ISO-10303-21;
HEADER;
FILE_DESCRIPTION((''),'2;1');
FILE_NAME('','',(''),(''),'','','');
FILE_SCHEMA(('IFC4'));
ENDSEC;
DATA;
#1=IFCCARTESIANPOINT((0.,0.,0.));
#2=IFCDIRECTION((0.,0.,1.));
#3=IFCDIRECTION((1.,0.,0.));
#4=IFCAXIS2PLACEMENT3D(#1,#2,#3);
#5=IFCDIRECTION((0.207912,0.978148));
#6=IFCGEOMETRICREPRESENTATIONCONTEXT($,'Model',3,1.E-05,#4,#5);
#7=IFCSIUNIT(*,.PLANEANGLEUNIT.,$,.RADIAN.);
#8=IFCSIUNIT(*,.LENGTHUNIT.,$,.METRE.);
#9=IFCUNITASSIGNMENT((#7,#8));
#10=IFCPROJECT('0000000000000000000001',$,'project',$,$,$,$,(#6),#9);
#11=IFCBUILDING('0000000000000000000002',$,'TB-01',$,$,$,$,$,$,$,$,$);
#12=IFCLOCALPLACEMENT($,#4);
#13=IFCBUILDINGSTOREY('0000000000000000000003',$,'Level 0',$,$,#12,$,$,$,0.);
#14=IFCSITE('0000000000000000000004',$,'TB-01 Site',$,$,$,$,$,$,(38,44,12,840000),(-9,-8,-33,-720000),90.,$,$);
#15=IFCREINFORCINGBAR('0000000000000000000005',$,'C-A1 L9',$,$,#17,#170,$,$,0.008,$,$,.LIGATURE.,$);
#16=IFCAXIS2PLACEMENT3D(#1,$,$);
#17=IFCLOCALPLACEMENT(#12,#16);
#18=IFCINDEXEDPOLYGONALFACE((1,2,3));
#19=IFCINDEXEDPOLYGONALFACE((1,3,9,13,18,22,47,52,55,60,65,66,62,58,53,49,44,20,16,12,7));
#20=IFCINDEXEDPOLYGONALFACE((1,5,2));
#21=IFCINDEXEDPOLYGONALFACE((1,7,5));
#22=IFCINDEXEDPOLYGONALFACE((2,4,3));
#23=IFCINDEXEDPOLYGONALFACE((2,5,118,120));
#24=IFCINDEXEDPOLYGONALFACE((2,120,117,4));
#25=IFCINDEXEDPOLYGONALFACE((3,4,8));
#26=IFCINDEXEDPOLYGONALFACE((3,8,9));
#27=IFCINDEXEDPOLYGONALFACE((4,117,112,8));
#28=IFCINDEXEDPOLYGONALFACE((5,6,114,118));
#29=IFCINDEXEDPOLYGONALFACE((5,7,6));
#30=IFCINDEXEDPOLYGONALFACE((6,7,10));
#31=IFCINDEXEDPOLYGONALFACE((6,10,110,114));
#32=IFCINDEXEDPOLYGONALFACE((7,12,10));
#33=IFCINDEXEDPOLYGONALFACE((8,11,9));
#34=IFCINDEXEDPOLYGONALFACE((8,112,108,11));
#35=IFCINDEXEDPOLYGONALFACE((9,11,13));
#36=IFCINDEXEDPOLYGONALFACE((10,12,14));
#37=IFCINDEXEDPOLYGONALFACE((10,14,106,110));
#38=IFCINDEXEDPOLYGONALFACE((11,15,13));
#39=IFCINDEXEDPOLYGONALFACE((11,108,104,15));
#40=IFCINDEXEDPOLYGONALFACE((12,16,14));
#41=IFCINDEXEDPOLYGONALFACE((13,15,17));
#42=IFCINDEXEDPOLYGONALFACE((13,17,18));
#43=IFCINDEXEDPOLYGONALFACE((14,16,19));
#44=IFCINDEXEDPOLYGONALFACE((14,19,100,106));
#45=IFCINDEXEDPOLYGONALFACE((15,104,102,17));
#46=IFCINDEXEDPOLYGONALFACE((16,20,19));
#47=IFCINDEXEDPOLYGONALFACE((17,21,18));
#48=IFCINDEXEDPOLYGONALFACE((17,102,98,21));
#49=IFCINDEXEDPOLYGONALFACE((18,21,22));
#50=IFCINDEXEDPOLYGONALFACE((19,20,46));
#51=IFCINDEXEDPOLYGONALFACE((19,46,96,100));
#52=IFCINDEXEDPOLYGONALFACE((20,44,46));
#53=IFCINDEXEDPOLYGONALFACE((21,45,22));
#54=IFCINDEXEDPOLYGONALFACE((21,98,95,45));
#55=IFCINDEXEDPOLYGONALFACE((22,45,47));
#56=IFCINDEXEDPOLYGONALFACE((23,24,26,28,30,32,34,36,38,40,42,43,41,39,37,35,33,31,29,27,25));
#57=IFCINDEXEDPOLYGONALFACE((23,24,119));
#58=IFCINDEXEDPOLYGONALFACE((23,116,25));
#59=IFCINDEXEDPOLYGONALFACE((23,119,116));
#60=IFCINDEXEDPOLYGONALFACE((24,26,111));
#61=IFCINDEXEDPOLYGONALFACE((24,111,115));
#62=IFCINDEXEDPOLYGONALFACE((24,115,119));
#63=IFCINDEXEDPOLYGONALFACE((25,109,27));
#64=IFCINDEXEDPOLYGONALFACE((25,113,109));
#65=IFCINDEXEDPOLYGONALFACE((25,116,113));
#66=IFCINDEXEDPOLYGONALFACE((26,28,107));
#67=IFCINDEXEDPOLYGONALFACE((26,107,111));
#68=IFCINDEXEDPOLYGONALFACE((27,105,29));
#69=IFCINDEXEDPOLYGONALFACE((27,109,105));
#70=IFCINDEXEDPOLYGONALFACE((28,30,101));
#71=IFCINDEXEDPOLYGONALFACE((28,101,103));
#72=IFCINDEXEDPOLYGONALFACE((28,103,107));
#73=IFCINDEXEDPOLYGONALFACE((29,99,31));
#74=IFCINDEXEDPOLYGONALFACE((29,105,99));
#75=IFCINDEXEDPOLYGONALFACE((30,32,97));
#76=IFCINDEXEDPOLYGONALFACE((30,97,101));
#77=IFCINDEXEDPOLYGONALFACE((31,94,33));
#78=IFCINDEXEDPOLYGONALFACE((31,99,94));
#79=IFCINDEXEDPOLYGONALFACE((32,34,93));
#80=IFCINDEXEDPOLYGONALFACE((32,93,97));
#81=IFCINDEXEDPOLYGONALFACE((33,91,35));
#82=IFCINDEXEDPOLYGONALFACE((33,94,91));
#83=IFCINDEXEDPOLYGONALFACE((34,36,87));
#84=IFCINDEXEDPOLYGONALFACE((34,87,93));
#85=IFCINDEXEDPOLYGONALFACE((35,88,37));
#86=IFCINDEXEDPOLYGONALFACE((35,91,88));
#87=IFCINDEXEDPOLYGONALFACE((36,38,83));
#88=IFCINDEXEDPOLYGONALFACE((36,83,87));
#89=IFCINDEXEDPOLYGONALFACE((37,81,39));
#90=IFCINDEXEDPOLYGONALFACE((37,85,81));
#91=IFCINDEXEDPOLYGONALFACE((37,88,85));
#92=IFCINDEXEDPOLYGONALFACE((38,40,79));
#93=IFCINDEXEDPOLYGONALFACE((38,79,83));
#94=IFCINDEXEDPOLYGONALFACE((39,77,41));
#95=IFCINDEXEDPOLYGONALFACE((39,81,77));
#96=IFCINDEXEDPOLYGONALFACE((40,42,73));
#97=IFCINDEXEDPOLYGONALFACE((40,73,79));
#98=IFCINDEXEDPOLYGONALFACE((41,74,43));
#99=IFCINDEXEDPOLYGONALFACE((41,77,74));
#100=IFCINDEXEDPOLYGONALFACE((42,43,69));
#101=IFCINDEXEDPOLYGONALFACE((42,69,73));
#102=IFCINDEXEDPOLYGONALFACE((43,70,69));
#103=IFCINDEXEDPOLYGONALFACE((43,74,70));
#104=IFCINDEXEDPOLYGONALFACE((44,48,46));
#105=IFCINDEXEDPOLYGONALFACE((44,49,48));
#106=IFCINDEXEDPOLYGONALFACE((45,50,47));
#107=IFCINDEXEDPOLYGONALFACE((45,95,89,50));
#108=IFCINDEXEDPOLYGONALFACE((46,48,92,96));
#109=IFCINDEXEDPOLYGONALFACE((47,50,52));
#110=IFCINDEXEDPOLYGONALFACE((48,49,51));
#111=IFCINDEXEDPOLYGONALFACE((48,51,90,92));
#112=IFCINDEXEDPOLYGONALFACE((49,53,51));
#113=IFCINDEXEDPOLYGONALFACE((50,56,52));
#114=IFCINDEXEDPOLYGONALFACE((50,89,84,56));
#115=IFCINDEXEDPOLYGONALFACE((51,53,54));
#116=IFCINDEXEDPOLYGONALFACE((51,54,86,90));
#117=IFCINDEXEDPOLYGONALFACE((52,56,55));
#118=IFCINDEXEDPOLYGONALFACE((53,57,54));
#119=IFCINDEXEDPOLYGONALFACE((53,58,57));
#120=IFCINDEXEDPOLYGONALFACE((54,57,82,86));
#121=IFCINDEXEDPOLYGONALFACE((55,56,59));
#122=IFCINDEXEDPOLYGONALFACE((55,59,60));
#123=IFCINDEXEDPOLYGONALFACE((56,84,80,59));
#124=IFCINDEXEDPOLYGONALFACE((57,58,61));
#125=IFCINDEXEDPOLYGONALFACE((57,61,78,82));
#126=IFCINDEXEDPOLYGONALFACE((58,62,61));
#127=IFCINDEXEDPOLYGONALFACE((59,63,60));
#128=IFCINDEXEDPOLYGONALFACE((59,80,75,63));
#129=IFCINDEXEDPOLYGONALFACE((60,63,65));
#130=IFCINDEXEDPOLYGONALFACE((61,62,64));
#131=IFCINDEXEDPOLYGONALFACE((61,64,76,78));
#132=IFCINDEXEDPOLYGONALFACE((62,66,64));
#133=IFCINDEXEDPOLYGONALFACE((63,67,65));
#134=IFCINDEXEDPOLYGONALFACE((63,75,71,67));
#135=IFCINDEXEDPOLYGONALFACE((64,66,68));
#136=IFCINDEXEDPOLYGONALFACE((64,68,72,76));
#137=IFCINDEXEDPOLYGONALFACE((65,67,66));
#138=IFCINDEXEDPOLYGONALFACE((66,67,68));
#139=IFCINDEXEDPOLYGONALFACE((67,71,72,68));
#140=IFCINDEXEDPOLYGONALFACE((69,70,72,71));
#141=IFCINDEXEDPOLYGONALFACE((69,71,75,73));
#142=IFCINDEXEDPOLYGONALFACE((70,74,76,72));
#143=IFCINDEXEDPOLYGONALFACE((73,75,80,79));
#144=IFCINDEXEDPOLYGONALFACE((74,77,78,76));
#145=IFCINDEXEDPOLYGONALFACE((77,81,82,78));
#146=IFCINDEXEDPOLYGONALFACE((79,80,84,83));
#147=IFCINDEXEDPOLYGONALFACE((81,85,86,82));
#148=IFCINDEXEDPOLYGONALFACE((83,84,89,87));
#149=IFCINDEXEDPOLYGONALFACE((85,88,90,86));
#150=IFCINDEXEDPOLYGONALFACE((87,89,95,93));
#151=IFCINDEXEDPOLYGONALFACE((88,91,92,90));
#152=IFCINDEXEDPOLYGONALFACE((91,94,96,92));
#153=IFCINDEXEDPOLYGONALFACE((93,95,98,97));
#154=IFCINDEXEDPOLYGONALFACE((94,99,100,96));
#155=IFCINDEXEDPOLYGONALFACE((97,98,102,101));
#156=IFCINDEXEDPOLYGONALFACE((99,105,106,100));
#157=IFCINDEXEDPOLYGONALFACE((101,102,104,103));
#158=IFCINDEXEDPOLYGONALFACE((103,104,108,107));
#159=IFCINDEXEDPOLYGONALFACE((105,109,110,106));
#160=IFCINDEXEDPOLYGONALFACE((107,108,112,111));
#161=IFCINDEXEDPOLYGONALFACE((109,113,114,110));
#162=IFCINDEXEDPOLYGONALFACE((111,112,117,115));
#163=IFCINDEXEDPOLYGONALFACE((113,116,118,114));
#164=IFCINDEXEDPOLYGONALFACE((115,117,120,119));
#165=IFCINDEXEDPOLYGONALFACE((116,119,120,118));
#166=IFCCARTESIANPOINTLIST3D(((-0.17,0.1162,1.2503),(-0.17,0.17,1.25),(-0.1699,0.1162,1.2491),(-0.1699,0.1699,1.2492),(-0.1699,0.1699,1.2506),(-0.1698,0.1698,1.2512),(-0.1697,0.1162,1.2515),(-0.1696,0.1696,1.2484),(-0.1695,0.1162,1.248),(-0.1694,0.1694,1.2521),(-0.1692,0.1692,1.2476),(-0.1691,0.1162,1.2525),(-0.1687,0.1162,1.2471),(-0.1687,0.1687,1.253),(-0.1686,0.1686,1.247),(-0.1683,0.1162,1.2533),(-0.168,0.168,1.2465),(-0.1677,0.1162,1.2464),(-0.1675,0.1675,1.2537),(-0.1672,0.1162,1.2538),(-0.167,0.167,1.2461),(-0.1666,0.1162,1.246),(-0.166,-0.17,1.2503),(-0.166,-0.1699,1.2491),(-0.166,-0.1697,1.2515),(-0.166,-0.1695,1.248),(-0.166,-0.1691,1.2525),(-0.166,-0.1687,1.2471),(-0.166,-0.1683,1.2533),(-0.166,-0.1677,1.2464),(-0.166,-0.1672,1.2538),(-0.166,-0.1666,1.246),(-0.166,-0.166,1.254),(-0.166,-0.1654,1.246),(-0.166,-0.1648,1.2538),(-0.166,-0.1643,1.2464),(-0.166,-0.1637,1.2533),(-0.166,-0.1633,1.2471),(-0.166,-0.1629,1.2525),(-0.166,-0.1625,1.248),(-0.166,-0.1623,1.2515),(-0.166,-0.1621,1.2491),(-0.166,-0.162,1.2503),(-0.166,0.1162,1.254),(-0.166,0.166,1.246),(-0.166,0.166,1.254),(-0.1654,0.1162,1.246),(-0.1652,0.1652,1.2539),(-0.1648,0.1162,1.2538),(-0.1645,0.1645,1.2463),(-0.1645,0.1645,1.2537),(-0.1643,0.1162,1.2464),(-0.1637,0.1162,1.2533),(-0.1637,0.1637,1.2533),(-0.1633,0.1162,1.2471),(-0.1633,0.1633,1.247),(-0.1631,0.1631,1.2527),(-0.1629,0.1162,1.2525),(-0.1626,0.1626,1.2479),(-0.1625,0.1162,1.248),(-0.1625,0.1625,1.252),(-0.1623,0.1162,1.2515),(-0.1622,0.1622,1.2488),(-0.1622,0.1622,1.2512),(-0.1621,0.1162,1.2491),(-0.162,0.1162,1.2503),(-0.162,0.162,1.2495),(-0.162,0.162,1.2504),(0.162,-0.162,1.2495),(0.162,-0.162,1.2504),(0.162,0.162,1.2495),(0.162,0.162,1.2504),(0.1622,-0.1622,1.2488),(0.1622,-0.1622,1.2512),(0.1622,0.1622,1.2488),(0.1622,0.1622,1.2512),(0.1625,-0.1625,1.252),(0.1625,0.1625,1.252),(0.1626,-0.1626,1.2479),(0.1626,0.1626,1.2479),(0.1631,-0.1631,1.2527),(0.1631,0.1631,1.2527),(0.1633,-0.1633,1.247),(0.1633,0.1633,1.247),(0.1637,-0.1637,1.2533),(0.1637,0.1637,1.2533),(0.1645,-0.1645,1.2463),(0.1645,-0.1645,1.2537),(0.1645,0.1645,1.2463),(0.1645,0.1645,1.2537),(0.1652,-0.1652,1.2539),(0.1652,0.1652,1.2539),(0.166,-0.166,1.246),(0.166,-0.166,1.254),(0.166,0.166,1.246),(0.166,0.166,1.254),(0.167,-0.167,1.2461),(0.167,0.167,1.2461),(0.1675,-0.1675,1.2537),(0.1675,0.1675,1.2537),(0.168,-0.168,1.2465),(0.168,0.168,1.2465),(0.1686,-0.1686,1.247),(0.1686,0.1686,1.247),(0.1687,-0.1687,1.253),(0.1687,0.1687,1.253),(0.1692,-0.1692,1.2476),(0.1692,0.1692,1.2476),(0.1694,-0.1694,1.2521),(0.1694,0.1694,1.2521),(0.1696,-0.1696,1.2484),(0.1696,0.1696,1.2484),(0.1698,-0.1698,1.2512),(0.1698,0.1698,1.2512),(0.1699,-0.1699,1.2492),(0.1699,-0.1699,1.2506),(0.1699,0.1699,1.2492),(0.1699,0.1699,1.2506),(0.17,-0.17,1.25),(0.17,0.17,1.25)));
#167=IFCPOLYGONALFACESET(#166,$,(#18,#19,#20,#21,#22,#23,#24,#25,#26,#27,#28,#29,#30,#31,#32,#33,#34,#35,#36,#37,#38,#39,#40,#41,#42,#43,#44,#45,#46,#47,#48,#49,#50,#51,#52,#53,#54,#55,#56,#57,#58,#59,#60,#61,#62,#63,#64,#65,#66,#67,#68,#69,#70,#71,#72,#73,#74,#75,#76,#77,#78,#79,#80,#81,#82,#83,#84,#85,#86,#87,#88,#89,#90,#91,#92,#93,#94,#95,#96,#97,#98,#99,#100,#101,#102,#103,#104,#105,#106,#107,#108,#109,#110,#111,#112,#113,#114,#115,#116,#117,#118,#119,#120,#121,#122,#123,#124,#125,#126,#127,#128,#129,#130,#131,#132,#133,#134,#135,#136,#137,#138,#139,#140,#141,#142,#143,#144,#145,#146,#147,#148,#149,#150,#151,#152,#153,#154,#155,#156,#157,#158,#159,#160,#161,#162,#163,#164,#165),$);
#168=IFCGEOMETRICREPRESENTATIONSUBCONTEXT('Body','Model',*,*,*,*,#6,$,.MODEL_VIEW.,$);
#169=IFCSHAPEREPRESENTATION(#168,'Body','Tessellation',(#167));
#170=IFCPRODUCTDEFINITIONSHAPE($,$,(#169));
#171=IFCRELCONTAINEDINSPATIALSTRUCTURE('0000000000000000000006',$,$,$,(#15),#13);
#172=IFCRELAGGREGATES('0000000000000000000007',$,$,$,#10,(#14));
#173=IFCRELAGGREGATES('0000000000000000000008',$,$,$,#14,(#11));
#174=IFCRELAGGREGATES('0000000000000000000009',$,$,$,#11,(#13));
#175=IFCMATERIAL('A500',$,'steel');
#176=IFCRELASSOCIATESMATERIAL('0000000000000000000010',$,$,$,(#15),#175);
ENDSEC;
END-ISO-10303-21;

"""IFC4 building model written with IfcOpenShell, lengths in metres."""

from ifc_helpers import new_model, entity, si_unit, direction, origin_with_axes, place, context, subcontext, project, spatial, material, element, save


model = new_model("IFC4")

# Units and contexts
model_context = context("Model", 3, precision=1e-05, world=origin_with_axes(), true_north=direction((0.207912, 0.978148)))
body_context = subcontext(model_context, "Body", "Model", "MODEL_VIEW")
ifc_project = project(units=[si_unit("PLANEANGLEUNIT", "RADIAN"), si_unit("LENGTHUNIT", "METRE")], contexts=[model_context])

# Site, building, storey
site = spatial("IfcSite", under=ifc_project, Name="TB-01 Site", RefLatitude=(38, 44, 12, 840000), RefLongitude=(-9, -8, -33, -720000), RefElevation=90.0)
building = spatial("IfcBuilding", under=site, Name="TB-01")
storey_placement = place(None, origin_with_axes())
storey = spatial("IfcBuildingStorey", under=building, at=storey_placement, Name="Level 0", Elevation=0.0)

# Reinforcing bar
ifc_material_1 = material(Name="A500", Category="steel")
reinforcing_bar_1_placement = place(storey_placement, origin_with_axes())
element("IfcReinforcingBar", 1, at=reinforcing_bar_1_placement, inside=storey, material=ifc_material_1, Name="C-A1 L9", NominalDiameter=0.008, PredefinedType="LIGATURE", context=body_context, shape_type="AdvancedSweptSolid", body=[
    entity("IfcSweptDiskSolid", entity("IfcPolyline", [entity("IfcCartesianPoint", [-0.166, -0.166, 1.25]), entity("IfcCartesianPoint", [0.166, -0.166, 1.25]), entity("IfcCartesianPoint", [0.166, 0.166, 1.25]), entity("IfcCartesianPoint", [-0.166, 0.166, 1.25]), entity("IfcCartesianPoint", [-0.166, 0.1162, 1.25])]), 0.004),
])

save(model, "model.ifc")
